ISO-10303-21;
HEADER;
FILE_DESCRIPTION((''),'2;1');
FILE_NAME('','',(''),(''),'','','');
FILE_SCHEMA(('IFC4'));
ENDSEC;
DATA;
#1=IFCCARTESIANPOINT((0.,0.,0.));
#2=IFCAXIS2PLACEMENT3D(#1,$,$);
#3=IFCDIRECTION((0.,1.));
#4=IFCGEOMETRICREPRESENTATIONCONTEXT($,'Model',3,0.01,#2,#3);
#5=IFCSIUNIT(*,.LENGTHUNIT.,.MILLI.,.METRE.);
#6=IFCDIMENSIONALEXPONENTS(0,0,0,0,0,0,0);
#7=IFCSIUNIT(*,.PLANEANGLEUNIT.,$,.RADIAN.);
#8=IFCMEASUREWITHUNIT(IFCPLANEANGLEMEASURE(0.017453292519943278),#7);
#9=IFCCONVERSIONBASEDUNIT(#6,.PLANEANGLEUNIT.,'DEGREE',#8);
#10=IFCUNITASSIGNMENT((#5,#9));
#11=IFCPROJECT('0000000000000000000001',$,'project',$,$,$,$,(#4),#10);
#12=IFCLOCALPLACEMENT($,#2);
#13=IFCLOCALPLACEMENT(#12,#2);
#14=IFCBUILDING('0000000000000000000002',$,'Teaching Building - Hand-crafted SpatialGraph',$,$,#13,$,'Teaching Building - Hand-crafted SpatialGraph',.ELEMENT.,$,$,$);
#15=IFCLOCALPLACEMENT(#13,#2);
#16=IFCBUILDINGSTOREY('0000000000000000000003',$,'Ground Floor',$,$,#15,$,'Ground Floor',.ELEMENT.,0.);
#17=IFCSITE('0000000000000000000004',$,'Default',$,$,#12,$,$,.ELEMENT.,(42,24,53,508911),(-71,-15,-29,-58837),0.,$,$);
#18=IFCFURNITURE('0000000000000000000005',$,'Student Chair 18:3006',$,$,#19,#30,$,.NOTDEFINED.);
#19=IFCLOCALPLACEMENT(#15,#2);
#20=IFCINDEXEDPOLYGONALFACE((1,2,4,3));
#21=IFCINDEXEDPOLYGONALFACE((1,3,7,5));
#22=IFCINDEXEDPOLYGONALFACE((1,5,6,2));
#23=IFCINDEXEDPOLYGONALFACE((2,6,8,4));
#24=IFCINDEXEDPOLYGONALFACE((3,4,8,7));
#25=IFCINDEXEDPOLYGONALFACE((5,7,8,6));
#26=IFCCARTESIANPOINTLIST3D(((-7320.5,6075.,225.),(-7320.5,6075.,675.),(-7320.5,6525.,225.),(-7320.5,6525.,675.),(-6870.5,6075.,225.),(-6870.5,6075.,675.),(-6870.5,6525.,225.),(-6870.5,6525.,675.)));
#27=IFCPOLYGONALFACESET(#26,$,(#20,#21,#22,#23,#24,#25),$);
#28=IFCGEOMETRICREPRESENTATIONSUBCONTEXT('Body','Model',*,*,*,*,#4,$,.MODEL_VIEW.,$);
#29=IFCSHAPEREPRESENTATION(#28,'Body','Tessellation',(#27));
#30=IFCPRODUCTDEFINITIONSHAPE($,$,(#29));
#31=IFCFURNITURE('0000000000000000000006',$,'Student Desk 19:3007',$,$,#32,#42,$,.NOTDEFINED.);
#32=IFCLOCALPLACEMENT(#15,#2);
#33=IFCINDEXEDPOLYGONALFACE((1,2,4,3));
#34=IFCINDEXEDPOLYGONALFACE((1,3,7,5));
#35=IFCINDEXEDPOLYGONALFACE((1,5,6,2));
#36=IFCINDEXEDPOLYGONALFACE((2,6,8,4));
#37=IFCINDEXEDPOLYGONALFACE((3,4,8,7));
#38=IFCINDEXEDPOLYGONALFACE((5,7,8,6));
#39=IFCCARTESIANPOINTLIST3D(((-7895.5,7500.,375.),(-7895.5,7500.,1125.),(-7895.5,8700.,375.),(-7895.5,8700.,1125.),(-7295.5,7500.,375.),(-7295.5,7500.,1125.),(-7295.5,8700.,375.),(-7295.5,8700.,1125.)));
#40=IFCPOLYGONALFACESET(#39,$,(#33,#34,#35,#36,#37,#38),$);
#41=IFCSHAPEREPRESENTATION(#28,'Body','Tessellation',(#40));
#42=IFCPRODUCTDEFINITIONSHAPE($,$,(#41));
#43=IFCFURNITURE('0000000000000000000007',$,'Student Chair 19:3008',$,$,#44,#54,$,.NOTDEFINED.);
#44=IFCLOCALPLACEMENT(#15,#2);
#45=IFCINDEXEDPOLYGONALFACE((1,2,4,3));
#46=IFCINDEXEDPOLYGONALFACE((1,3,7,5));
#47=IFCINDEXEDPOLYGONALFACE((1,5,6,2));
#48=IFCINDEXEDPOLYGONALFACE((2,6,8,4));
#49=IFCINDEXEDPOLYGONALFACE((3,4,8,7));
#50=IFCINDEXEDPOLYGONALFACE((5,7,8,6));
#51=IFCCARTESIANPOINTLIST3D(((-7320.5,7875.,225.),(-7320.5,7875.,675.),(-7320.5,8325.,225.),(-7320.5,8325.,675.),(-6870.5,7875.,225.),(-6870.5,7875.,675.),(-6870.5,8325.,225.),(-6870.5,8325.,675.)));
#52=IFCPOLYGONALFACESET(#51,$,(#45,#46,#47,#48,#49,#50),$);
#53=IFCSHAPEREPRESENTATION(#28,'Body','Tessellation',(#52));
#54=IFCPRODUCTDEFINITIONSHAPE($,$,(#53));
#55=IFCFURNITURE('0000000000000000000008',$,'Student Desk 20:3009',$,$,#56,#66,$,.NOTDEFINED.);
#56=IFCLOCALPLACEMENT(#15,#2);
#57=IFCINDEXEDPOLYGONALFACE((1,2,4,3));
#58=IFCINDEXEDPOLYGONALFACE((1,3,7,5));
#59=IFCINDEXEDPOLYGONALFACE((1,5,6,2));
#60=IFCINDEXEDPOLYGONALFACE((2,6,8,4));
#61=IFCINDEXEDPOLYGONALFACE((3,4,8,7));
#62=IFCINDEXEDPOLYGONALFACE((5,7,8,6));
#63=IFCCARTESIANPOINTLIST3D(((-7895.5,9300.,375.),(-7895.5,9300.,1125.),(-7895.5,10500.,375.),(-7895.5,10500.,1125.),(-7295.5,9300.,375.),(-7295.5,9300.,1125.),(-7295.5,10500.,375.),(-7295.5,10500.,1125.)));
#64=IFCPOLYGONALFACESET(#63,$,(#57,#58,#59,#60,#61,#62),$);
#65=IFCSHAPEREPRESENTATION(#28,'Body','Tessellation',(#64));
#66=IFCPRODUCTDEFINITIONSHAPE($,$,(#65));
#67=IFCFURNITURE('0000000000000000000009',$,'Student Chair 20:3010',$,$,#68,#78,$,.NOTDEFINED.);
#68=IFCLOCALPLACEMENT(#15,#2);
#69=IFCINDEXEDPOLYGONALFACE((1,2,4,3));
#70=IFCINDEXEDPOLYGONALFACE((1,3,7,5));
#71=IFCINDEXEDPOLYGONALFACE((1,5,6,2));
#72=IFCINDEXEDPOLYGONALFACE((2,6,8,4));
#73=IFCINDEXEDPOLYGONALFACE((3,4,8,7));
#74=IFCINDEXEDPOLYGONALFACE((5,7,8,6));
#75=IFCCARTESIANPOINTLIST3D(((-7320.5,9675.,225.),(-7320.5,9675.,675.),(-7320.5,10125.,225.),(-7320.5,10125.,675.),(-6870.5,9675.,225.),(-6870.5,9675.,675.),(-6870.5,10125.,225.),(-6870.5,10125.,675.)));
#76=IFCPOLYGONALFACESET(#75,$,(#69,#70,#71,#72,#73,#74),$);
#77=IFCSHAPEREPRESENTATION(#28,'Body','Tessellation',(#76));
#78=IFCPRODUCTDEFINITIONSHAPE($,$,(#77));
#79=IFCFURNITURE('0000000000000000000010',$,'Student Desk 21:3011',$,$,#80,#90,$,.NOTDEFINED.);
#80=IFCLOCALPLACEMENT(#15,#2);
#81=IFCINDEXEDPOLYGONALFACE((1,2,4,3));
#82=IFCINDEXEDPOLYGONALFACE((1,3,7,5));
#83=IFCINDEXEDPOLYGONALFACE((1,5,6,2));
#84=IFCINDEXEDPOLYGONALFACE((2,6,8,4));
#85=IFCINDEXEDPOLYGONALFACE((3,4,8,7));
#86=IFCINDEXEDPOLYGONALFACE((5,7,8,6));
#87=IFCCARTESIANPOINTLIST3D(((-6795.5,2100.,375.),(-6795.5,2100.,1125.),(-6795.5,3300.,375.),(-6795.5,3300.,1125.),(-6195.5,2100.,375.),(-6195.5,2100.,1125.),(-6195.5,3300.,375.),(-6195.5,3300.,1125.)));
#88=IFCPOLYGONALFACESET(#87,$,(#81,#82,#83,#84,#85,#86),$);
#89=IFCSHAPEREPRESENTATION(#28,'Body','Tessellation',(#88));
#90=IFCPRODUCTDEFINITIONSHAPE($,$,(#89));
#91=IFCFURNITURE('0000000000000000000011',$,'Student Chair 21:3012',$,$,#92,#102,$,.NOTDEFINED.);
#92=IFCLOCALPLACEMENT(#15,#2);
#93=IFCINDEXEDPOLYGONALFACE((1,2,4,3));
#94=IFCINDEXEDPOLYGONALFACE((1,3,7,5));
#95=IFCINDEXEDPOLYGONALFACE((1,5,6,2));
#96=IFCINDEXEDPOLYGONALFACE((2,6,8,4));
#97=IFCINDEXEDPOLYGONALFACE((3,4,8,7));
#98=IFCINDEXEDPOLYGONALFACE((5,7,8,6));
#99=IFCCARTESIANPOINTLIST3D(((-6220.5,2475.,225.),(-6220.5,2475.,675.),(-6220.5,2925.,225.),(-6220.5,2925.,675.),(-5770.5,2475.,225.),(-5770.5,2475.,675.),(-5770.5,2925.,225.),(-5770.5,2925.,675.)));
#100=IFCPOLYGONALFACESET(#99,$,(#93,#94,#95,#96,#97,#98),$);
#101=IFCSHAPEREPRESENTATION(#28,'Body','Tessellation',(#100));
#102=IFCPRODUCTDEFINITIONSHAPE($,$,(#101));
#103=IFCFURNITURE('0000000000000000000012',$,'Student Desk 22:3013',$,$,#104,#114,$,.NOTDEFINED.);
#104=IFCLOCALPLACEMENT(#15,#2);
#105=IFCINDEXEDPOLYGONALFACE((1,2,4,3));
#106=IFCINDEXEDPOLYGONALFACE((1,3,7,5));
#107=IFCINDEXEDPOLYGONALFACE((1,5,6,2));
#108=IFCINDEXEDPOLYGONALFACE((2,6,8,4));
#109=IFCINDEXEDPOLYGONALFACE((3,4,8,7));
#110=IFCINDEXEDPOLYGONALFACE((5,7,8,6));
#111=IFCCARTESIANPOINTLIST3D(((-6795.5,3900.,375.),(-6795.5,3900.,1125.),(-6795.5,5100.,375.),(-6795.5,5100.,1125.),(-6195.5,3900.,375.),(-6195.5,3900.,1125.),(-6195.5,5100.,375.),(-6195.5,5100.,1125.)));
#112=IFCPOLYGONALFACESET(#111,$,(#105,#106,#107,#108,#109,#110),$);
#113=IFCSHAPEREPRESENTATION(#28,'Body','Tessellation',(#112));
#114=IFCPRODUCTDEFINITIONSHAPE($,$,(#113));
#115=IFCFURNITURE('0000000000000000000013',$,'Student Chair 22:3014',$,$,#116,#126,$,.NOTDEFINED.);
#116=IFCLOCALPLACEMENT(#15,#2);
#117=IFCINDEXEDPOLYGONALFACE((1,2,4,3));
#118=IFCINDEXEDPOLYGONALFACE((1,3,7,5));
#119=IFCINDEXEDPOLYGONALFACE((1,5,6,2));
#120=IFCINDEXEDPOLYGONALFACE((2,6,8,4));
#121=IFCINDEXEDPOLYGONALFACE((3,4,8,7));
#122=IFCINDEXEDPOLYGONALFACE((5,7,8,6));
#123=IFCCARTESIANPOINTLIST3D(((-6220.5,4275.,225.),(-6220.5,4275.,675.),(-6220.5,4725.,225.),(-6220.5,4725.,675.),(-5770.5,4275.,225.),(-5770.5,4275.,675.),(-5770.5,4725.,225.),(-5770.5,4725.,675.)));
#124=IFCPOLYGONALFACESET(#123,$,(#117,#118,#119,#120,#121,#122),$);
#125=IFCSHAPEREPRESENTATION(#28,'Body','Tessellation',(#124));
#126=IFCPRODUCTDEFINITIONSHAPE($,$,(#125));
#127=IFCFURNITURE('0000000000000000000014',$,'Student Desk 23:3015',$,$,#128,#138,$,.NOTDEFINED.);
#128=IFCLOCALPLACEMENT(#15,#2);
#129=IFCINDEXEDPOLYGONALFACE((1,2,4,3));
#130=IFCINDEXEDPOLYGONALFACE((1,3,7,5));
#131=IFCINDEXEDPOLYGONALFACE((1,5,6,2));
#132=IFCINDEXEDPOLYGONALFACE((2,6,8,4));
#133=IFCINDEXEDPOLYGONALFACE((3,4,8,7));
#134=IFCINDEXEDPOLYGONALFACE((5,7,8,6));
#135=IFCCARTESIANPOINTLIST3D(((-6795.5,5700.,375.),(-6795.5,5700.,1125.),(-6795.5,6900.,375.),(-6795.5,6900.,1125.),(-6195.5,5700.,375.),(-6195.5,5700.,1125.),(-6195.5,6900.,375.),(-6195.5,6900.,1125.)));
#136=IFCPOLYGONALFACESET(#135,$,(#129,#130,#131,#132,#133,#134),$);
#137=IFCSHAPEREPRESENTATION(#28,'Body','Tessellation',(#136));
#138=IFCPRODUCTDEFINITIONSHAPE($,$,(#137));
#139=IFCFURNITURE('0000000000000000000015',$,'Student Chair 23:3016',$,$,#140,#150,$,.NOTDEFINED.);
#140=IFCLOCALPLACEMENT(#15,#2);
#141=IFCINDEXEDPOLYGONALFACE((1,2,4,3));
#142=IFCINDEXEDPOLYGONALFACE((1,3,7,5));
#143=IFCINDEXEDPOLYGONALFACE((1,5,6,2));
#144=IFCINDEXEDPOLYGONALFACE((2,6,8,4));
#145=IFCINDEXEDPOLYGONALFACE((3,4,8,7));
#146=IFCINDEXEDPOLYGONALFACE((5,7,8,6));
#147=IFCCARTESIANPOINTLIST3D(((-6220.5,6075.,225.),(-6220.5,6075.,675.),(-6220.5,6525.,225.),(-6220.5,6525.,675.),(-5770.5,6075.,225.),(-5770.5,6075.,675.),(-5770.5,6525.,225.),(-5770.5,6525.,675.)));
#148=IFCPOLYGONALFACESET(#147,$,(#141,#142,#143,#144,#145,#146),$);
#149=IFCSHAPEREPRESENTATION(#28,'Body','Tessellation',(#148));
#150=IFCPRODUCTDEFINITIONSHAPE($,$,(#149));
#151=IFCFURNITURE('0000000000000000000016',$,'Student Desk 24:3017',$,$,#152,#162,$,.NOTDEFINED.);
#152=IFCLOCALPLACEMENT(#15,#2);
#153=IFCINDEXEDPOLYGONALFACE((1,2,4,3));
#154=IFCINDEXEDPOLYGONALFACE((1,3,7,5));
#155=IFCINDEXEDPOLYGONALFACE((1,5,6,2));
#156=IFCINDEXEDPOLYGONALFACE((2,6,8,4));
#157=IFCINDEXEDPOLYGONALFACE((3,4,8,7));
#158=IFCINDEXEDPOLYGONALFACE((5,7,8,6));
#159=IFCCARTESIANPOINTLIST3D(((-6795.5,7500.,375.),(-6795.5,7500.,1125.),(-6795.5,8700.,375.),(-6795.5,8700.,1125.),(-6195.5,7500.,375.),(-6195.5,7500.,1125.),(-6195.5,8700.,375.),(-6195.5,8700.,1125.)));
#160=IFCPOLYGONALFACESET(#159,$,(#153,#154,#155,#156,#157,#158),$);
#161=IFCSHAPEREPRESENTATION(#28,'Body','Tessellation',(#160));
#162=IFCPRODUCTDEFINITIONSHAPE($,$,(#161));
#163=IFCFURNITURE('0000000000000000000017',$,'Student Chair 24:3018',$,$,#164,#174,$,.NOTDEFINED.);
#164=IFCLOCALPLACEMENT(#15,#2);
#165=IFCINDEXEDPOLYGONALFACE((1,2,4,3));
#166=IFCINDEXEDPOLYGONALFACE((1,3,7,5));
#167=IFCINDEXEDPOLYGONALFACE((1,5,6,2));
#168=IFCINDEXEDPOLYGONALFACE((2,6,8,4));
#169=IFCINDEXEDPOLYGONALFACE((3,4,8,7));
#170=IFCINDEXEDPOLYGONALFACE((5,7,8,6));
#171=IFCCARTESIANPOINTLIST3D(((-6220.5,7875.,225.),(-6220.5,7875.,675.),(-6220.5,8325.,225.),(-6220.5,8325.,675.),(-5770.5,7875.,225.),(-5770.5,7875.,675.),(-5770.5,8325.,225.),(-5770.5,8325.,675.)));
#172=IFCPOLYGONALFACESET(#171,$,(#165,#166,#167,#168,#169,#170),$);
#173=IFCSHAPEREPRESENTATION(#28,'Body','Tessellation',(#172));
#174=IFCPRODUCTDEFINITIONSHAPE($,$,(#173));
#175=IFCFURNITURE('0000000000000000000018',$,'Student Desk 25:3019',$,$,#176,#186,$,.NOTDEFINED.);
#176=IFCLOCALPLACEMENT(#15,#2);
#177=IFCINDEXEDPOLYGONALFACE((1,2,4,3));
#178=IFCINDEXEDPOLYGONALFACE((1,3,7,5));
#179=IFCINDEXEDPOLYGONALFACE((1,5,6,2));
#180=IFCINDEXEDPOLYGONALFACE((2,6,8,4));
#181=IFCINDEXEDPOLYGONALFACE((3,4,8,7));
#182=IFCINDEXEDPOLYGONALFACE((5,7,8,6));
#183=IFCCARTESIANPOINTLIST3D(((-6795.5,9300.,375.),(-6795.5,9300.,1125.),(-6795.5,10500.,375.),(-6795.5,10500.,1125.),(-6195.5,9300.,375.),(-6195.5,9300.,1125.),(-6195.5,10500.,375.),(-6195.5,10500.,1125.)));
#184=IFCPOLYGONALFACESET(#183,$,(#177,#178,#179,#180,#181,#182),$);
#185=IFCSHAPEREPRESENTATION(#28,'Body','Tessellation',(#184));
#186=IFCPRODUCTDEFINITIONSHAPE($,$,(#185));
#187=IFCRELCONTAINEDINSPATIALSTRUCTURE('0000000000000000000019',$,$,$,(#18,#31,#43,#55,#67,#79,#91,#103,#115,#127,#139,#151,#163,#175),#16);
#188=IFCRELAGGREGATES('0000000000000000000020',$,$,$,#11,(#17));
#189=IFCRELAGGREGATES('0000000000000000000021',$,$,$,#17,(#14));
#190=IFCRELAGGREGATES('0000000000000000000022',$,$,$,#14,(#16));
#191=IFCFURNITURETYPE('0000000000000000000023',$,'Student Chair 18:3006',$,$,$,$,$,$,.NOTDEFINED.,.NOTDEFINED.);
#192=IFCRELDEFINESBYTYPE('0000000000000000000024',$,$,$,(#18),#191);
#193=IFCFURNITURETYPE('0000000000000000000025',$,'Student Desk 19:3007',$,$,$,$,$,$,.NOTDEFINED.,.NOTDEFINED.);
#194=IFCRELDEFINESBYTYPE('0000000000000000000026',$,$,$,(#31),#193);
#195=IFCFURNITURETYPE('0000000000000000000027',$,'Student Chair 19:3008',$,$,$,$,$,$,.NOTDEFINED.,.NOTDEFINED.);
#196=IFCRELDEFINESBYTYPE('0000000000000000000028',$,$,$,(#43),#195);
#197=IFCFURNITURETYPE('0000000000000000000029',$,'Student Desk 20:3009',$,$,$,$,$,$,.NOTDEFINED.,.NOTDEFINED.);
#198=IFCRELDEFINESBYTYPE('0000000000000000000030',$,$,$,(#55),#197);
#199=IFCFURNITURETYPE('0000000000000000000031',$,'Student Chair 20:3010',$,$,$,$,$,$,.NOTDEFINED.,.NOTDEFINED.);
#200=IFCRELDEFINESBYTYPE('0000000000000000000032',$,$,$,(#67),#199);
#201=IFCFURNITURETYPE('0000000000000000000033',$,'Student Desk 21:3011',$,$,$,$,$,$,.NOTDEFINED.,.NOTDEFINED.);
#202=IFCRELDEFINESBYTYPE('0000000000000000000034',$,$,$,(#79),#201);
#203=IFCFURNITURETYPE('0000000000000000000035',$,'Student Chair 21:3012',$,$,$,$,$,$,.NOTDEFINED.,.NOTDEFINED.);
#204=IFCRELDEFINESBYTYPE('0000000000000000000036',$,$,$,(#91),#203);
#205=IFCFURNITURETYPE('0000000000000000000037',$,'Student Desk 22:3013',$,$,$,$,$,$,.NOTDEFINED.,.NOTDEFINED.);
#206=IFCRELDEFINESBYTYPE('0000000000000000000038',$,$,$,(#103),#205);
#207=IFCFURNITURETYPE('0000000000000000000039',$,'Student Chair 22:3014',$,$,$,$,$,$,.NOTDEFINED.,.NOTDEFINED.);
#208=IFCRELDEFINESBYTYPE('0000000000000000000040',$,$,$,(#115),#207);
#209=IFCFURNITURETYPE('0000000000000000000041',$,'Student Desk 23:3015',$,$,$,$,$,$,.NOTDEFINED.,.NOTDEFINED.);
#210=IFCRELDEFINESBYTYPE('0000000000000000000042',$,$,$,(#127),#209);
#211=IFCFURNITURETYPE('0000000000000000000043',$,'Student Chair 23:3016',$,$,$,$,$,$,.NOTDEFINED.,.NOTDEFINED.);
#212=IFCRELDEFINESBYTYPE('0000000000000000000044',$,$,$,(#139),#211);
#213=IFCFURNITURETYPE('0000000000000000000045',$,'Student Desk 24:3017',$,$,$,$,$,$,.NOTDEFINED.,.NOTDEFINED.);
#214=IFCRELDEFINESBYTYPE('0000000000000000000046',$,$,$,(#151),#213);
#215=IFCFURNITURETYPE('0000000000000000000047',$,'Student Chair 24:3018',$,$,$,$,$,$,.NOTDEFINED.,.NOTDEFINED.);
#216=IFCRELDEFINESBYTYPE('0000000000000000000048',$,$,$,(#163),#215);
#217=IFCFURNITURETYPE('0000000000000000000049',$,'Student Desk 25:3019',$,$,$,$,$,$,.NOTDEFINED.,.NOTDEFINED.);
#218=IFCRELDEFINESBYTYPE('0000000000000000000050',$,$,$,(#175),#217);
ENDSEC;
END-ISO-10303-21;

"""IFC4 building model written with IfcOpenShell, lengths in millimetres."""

from ifc_helpers import new_model, entity, si_unit, converted_unit, direction, frame, frame_2d, origin, origin_2d_with_axis, place, context, subcontext, project, spatial, rectangle, extrude, type_object, element, save


model = new_model("IFC4")

# Units and contexts
model_context = context("Model", 3, precision=0.01, world=origin(), true_north=direction((0.0, 1.0)))
body_context = subcontext(model_context, "Body", "Model", "MODEL_VIEW")
ifc_project = project(units=[si_unit("LENGTHUNIT", "METRE", prefix="MILLI"), converted_unit("PLANEANGLEUNIT", "DEGREE", entity("IfcPlaneAngleMeasure", 0.017453292519943278), si_unit("PLANEANGLEUNIT", "RADIAN"), dimensions=[0, 0, 0, 0, 0, 0, 0])], contexts=[model_context])

# Site, building, storey
site_placement = place(None, origin())
site = spatial("IfcSite", under=ifc_project, at=site_placement, Name="Default", CompositionType="ELEMENT", RefLatitude=(42, 24, 53, 508911), RefLongitude=(-71, -15, -29, -58837), RefElevation=0.0)
building_placement = place(site_placement, origin())
building = spatial("IfcBuilding", under=site, at=building_placement, Name="Teaching Building - Hand-crafted SpatialGraph", LongName="Teaching Building - Hand-crafted SpatialGraph", CompositionType="ELEMENT")
storey_placement = place(building_placement, origin())
storey = spatial("IfcBuildingStorey", under=building, at=storey_placement, Name="Ground Floor", LongName="Ground Floor", CompositionType="ELEMENT", Elevation=0.0)

# Furniture
furniture_type_1 = type_object("IfcFurnitureType", Name="Student Chair 18:3006", PredefinedType="NOTDEFINED")
furniture_1_placement = place(storey_placement, origin())
element("IfcFurniture", 1, at=furniture_1_placement, inside=storey, type_object=furniture_type_1, Name="Student Chair 18:3006", PredefinedType="NOTDEFINED", context=body_context, shape_type="SweptSolid", body=[
    extrude(rectangle(XDim=450.0, YDim=450.0, at=origin_2d_with_axis()), frame((-7095.5, 6300.0, 225.0)), (0.0, 0.0, 1.0), 450.0),
])
furniture_type_2 = type_object("IfcFurnitureType", Name="Student Desk 19:3007", PredefinedType="NOTDEFINED")
furniture_2_placement = place(storey_placement, origin())
element("IfcFurniture", 2, at=furniture_2_placement, inside=storey, type_object=furniture_type_2, Name="Student Desk 19:3007", PredefinedType="NOTDEFINED", context=body_context, shape_type="SweptSolid", body=[
    extrude(rectangle(XDim=1200.0, YDim=600.0, at=origin_2d_with_axis()), frame((-7595.5, 8100.0, 375.0), z_axis=(0.0, 0.0, 1.0), x_axis=(0.0, 1.0, 0.0)), (0.0, 0.0, 1.0), 750.0),
])
furniture_type_3 = type_object("IfcFurnitureType", Name="Student Chair 19:3008", PredefinedType="NOTDEFINED")
furniture_3_placement = place(storey_placement, origin())
element("IfcFurniture", 3, at=furniture_3_placement, inside=storey, type_object=furniture_type_3, Name="Student Chair 19:3008", PredefinedType="NOTDEFINED", context=body_context, shape_type="SweptSolid", body=[
    extrude(rectangle(XDim=450.0, YDim=450.0, at=origin_2d_with_axis()), frame((-7095.5, 8100.0, 225.0)), (0.0, 0.0, 1.0), 450.0),
])
furniture_type_4 = type_object("IfcFurnitureType", Name="Student Desk 20:3009", PredefinedType="NOTDEFINED")
furniture_4_placement = place(storey_placement, origin())
element("IfcFurniture", 4, at=furniture_4_placement, inside=storey, type_object=furniture_type_4, Name="Student Desk 20:3009", PredefinedType="NOTDEFINED", context=body_context, shape_type="SweptSolid", body=[
    extrude(rectangle(XDim=1200.0, YDim=600.0, at=origin_2d_with_axis()), frame((-7595.5, 9900.0, 375.0), z_axis=(0.0, 0.0, 1.0), x_axis=(0.0, 1.0, 0.0)), (0.0, 0.0, 1.0), 750.0),
])
furniture_type_5 = type_object("IfcFurnitureType", Name="Student Chair 20:3010", PredefinedType="NOTDEFINED")
furniture_5_placement = place(storey_placement, origin())
element("IfcFurniture", 5, at=furniture_5_placement, inside=storey, type_object=furniture_type_5, Name="Student Chair 20:3010", PredefinedType="NOTDEFINED", context=body_context, shape_type="SweptSolid", body=[
    extrude(rectangle(XDim=450.0, YDim=450.0, at=frame_2d((0.0, 0.0), x_axis=(1.0, 0.0))), frame((-7095.5, 9900.0, 225.0)), (0.0, 0.0, 1.0), 450.0),
])
furniture_type_6 = type_object("IfcFurnitureType", Name="Student Desk 21:3011", PredefinedType="NOTDEFINED")
furniture_6_placement = place(storey_placement, origin())
element("IfcFurniture", 6, at=furniture_6_placement, inside=storey, type_object=furniture_type_6, Name="Student Desk 21:3011", PredefinedType="NOTDEFINED", context=body_context, shape_type="SweptSolid", body=[
    extrude(rectangle(XDim=1200.0, YDim=600.0, at=origin_2d_with_axis()), frame((-6495.5, 2700.0, 375.0), z_axis=(0.0, 0.0, 1.0), x_axis=(0.0, 1.0, 0.0)), (0.0, 0.0, 1.0), 750.0),
])
furniture_type_7 = type_object("IfcFurnitureType", Name="Student Chair 21:3012", PredefinedType="NOTDEFINED")
furniture_7_placement = place(storey_placement, origin())
element("IfcFurniture", 7, at=furniture_7_placement, inside=storey, type_object=furniture_type_7, Name="Student Chair 21:3012", PredefinedType="NOTDEFINED", context=body_context, shape_type="SweptSolid", body=[
    extrude(rectangle(XDim=450.0, YDim=450.0, at=origin_2d_with_axis()), frame((-5995.5, 2700.0, 225.0)), (0.0, 0.0, 1.0), 450.0),
])
furniture_type_8 = type_object("IfcFurnitureType", Name="Student Desk 22:3013", PredefinedType="NOTDEFINED")
furniture_8_placement = place(storey_placement, origin())
element("IfcFurniture", 8, at=furniture_8_placement, inside=storey, type_object=furniture_type_8, Name="Student Desk 22:3013", PredefinedType="NOTDEFINED", context=body_context, shape_type="SweptSolid", body=[
    extrude(rectangle(XDim=1200.0, YDim=600.0, at=frame_2d((0.0, 0.0), x_axis=(1.0, 0.0))), frame((-6495.5, 4500.0, 375.0), z_axis=(0.0, 0.0, 1.0), x_axis=(0.0, 1.0, 0.0)), (0.0, 0.0, 1.0), 750.0),
])
furniture_type_9 = type_object("IfcFurnitureType", Name="Student Chair 22:3014", PredefinedType="NOTDEFINED")
furniture_9_placement = place(storey_placement, origin())
element("IfcFurniture", 9, at=furniture_9_placement, inside=storey, type_object=furniture_type_9, Name="Student Chair 22:3014", PredefinedType="NOTDEFINED", context=body_context, shape_type="SweptSolid", body=[
    extrude(rectangle(XDim=450.0, YDim=450.0, at=origin_2d_with_axis()), frame((-5995.5, 4500.0, 225.0)), (0.0, 0.0, 1.0), 450.0),
])
furniture_type_10 = type_object("IfcFurnitureType", Name="Student Desk 23:3015", PredefinedType="NOTDEFINED")
furniture_10_placement = place(storey_placement, origin())
element("IfcFurniture", 10, at=furniture_10_placement, inside=storey, type_object=furniture_type_10, Name="Student Desk 23:3015", PredefinedType="NOTDEFINED", context=body_context, shape_type="SweptSolid", body=[
    extrude(rectangle(XDim=1200.0, YDim=600.0, at=origin_2d_with_axis()), frame((-6495.5, 6300.0, 375.0), z_axis=(0.0, 0.0, 1.0), x_axis=(0.0, 1.0, 0.0)), (0.0, 0.0, 1.0), 750.0),
])
furniture_type_11 = type_object("IfcFurnitureType", Name="Student Chair 23:3016", PredefinedType="NOTDEFINED")
furniture_11_placement = place(storey_placement, origin())
element("IfcFurniture", 11, at=furniture_11_placement, inside=storey, type_object=furniture_type_11, Name="Student Chair 23:3016", PredefinedType="NOTDEFINED", context=body_context, shape_type="SweptSolid", body=[
    extrude(rectangle(XDim=450.0, YDim=450.0, at=origin_2d_with_axis()), frame((-5995.5, 6300.0, 225.0)), (0.0, 0.0, 1.0), 450.0),
])
furniture_type_12 = type_object("IfcFurnitureType", Name="Student Desk 24:3017", PredefinedType="NOTDEFINED")
furniture_12_placement = place(storey_placement, origin())
element("IfcFurniture", 12, at=furniture_12_placement, inside=storey, type_object=furniture_type_12, Name="Student Desk 24:3017", PredefinedType="NOTDEFINED", context=body_context, shape_type="SweptSolid", body=[
    extrude(rectangle(XDim=1200.0, YDim=600.0, at=origin_2d_with_axis()), frame((-6495.5, 8100.0, 375.0), z_axis=(0.0, 0.0, 1.0), x_axis=(0.0, 1.0, 0.0)), (0.0, 0.0, 1.0), 750.0),
])
furniture_type_13 = type_object("IfcFurnitureType", Name="Student Chair 24:3018", PredefinedType="NOTDEFINED")
furniture_13_placement = place(storey_placement, origin())
element("IfcFurniture", 13, at=furniture_13_placement, inside=storey, type_object=furniture_type_13, Name="Student Chair 24:3018", PredefinedType="NOTDEFINED", context=body_context, shape_type="SweptSolid", body=[
    extrude(rectangle(XDim=450.0, YDim=450.0, at=origin_2d_with_axis()), frame((-5995.5, 8100.0, 225.0)), (0.0, 0.0, 1.0), 450.0),
])
furniture_type_14 = type_object("IfcFurnitureType", Name="Student Desk 25:3019", PredefinedType="NOTDEFINED")
furniture_14_placement = place(storey_placement, origin())
element("IfcFurniture", 14, at=furniture_14_placement, inside=storey, type_object=furniture_type_14, Name="Student Desk 25:3019", PredefinedType="NOTDEFINED", context=body_context, shape_type="SweptSolid", body=[
    extrude(rectangle(XDim=1200.0, YDim=600.0, at=origin_2d_with_axis()), frame((-6495.5, 9900.0, 375.0), z_axis=(0.0, 0.0, 1.0), x_axis=(0.0, 1.0, 0.0)), (0.0, 0.0, 1.0), 750.0),
])

save(model, "model.ifc")
